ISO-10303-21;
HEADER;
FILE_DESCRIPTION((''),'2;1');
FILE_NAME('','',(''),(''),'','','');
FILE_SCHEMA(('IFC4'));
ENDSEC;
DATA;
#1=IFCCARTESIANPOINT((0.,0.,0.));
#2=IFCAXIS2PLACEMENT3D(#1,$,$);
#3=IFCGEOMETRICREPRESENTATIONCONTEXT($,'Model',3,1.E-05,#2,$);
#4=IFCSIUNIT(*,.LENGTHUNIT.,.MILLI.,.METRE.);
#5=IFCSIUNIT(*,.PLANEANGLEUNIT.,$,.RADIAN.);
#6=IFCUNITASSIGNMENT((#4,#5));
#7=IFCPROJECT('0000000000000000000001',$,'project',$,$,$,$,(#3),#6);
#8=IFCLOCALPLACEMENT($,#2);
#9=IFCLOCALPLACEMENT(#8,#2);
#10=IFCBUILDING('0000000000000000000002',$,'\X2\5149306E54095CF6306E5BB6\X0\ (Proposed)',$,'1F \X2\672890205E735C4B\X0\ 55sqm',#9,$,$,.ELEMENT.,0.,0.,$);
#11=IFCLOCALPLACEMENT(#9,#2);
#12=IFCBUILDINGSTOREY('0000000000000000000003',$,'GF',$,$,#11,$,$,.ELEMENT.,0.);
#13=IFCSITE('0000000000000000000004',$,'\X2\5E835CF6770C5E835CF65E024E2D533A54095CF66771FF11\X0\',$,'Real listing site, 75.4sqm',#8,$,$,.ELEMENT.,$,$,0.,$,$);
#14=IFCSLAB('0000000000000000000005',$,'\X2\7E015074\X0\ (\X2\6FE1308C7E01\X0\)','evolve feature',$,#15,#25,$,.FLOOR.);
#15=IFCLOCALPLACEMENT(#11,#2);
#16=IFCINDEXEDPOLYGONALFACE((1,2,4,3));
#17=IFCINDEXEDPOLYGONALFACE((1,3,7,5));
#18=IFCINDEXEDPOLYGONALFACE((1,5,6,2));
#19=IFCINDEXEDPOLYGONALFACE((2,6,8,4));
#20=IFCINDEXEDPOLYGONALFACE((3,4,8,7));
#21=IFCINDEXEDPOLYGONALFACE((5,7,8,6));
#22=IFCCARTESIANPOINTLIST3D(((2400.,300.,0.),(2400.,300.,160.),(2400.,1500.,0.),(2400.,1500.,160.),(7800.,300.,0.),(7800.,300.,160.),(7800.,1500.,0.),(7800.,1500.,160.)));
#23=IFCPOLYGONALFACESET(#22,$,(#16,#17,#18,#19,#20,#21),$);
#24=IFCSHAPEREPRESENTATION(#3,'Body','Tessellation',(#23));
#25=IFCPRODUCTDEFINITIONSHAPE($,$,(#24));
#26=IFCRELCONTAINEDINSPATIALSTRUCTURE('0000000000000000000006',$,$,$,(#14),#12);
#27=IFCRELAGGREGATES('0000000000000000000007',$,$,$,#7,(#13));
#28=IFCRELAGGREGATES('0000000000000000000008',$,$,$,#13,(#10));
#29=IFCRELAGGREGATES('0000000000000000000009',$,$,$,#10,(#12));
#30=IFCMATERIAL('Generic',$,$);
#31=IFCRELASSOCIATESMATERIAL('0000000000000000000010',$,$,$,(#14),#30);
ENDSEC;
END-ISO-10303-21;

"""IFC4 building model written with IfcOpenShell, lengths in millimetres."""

from ifc_helpers import new_model, si_unit, frame, frame_2d, origin, place, context, project, spatial, rectangle, extrude, material, element, save


model = new_model("IFC4")

# Units and contexts
model_context = context("Model", 3, precision=1e-05, world=origin())
ifc_project = project(units=[si_unit("LENGTHUNIT", "METRE", prefix="MILLI"), si_unit("PLANEANGLEUNIT", "RADIAN")], contexts=[model_context])

# Site, building, storey
site_placement = place(None, origin())
site = spatial("IfcSite", under=ifc_project, at=site_placement, Name="広島県広島市中区吉島東１", ObjectType="Real listing site, 75.4sqm", CompositionType="ELEMENT", RefElevation=0.0)
building_placement = place(site_placement, origin())
building = spatial("IfcBuilding", under=site, at=building_placement, Name="光の吉島の家 (Proposed)", ObjectType="1F 木造平屋 55sqm", CompositionType="ELEMENT", ElevationOfRefHeight=0.0, ElevationOfTerrain=0.0)
storey_placement = place(building_placement, origin())
storey = spatial("IfcBuildingStorey", under=building, at=storey_placement, Name="GF", CompositionType="ELEMENT", Elevation=0.0)

# Slab
ifc_material_1 = material(Name="Generic")
slab_1_placement = place(storey_placement, frame((1200.0, 150.0, 0.0)))
element("IfcSlab", 1, at=slab_1_placement, inside=storey, material=ifc_material_1, Name="縁側 (濡れ縁)", Description="evolve feature", PredefinedType="FLOOR", context=model_context, shape_type="SweptSolid", body=[
    extrude(rectangle(XDim=5400.0, YDim=1200.0, at=frame_2d((2700.0, 600.0))), frame((1200.0, 150.0, 0.0)), (0.0, 0.0, 1.0), 160.0),
])

save(model, "model.ifc")
